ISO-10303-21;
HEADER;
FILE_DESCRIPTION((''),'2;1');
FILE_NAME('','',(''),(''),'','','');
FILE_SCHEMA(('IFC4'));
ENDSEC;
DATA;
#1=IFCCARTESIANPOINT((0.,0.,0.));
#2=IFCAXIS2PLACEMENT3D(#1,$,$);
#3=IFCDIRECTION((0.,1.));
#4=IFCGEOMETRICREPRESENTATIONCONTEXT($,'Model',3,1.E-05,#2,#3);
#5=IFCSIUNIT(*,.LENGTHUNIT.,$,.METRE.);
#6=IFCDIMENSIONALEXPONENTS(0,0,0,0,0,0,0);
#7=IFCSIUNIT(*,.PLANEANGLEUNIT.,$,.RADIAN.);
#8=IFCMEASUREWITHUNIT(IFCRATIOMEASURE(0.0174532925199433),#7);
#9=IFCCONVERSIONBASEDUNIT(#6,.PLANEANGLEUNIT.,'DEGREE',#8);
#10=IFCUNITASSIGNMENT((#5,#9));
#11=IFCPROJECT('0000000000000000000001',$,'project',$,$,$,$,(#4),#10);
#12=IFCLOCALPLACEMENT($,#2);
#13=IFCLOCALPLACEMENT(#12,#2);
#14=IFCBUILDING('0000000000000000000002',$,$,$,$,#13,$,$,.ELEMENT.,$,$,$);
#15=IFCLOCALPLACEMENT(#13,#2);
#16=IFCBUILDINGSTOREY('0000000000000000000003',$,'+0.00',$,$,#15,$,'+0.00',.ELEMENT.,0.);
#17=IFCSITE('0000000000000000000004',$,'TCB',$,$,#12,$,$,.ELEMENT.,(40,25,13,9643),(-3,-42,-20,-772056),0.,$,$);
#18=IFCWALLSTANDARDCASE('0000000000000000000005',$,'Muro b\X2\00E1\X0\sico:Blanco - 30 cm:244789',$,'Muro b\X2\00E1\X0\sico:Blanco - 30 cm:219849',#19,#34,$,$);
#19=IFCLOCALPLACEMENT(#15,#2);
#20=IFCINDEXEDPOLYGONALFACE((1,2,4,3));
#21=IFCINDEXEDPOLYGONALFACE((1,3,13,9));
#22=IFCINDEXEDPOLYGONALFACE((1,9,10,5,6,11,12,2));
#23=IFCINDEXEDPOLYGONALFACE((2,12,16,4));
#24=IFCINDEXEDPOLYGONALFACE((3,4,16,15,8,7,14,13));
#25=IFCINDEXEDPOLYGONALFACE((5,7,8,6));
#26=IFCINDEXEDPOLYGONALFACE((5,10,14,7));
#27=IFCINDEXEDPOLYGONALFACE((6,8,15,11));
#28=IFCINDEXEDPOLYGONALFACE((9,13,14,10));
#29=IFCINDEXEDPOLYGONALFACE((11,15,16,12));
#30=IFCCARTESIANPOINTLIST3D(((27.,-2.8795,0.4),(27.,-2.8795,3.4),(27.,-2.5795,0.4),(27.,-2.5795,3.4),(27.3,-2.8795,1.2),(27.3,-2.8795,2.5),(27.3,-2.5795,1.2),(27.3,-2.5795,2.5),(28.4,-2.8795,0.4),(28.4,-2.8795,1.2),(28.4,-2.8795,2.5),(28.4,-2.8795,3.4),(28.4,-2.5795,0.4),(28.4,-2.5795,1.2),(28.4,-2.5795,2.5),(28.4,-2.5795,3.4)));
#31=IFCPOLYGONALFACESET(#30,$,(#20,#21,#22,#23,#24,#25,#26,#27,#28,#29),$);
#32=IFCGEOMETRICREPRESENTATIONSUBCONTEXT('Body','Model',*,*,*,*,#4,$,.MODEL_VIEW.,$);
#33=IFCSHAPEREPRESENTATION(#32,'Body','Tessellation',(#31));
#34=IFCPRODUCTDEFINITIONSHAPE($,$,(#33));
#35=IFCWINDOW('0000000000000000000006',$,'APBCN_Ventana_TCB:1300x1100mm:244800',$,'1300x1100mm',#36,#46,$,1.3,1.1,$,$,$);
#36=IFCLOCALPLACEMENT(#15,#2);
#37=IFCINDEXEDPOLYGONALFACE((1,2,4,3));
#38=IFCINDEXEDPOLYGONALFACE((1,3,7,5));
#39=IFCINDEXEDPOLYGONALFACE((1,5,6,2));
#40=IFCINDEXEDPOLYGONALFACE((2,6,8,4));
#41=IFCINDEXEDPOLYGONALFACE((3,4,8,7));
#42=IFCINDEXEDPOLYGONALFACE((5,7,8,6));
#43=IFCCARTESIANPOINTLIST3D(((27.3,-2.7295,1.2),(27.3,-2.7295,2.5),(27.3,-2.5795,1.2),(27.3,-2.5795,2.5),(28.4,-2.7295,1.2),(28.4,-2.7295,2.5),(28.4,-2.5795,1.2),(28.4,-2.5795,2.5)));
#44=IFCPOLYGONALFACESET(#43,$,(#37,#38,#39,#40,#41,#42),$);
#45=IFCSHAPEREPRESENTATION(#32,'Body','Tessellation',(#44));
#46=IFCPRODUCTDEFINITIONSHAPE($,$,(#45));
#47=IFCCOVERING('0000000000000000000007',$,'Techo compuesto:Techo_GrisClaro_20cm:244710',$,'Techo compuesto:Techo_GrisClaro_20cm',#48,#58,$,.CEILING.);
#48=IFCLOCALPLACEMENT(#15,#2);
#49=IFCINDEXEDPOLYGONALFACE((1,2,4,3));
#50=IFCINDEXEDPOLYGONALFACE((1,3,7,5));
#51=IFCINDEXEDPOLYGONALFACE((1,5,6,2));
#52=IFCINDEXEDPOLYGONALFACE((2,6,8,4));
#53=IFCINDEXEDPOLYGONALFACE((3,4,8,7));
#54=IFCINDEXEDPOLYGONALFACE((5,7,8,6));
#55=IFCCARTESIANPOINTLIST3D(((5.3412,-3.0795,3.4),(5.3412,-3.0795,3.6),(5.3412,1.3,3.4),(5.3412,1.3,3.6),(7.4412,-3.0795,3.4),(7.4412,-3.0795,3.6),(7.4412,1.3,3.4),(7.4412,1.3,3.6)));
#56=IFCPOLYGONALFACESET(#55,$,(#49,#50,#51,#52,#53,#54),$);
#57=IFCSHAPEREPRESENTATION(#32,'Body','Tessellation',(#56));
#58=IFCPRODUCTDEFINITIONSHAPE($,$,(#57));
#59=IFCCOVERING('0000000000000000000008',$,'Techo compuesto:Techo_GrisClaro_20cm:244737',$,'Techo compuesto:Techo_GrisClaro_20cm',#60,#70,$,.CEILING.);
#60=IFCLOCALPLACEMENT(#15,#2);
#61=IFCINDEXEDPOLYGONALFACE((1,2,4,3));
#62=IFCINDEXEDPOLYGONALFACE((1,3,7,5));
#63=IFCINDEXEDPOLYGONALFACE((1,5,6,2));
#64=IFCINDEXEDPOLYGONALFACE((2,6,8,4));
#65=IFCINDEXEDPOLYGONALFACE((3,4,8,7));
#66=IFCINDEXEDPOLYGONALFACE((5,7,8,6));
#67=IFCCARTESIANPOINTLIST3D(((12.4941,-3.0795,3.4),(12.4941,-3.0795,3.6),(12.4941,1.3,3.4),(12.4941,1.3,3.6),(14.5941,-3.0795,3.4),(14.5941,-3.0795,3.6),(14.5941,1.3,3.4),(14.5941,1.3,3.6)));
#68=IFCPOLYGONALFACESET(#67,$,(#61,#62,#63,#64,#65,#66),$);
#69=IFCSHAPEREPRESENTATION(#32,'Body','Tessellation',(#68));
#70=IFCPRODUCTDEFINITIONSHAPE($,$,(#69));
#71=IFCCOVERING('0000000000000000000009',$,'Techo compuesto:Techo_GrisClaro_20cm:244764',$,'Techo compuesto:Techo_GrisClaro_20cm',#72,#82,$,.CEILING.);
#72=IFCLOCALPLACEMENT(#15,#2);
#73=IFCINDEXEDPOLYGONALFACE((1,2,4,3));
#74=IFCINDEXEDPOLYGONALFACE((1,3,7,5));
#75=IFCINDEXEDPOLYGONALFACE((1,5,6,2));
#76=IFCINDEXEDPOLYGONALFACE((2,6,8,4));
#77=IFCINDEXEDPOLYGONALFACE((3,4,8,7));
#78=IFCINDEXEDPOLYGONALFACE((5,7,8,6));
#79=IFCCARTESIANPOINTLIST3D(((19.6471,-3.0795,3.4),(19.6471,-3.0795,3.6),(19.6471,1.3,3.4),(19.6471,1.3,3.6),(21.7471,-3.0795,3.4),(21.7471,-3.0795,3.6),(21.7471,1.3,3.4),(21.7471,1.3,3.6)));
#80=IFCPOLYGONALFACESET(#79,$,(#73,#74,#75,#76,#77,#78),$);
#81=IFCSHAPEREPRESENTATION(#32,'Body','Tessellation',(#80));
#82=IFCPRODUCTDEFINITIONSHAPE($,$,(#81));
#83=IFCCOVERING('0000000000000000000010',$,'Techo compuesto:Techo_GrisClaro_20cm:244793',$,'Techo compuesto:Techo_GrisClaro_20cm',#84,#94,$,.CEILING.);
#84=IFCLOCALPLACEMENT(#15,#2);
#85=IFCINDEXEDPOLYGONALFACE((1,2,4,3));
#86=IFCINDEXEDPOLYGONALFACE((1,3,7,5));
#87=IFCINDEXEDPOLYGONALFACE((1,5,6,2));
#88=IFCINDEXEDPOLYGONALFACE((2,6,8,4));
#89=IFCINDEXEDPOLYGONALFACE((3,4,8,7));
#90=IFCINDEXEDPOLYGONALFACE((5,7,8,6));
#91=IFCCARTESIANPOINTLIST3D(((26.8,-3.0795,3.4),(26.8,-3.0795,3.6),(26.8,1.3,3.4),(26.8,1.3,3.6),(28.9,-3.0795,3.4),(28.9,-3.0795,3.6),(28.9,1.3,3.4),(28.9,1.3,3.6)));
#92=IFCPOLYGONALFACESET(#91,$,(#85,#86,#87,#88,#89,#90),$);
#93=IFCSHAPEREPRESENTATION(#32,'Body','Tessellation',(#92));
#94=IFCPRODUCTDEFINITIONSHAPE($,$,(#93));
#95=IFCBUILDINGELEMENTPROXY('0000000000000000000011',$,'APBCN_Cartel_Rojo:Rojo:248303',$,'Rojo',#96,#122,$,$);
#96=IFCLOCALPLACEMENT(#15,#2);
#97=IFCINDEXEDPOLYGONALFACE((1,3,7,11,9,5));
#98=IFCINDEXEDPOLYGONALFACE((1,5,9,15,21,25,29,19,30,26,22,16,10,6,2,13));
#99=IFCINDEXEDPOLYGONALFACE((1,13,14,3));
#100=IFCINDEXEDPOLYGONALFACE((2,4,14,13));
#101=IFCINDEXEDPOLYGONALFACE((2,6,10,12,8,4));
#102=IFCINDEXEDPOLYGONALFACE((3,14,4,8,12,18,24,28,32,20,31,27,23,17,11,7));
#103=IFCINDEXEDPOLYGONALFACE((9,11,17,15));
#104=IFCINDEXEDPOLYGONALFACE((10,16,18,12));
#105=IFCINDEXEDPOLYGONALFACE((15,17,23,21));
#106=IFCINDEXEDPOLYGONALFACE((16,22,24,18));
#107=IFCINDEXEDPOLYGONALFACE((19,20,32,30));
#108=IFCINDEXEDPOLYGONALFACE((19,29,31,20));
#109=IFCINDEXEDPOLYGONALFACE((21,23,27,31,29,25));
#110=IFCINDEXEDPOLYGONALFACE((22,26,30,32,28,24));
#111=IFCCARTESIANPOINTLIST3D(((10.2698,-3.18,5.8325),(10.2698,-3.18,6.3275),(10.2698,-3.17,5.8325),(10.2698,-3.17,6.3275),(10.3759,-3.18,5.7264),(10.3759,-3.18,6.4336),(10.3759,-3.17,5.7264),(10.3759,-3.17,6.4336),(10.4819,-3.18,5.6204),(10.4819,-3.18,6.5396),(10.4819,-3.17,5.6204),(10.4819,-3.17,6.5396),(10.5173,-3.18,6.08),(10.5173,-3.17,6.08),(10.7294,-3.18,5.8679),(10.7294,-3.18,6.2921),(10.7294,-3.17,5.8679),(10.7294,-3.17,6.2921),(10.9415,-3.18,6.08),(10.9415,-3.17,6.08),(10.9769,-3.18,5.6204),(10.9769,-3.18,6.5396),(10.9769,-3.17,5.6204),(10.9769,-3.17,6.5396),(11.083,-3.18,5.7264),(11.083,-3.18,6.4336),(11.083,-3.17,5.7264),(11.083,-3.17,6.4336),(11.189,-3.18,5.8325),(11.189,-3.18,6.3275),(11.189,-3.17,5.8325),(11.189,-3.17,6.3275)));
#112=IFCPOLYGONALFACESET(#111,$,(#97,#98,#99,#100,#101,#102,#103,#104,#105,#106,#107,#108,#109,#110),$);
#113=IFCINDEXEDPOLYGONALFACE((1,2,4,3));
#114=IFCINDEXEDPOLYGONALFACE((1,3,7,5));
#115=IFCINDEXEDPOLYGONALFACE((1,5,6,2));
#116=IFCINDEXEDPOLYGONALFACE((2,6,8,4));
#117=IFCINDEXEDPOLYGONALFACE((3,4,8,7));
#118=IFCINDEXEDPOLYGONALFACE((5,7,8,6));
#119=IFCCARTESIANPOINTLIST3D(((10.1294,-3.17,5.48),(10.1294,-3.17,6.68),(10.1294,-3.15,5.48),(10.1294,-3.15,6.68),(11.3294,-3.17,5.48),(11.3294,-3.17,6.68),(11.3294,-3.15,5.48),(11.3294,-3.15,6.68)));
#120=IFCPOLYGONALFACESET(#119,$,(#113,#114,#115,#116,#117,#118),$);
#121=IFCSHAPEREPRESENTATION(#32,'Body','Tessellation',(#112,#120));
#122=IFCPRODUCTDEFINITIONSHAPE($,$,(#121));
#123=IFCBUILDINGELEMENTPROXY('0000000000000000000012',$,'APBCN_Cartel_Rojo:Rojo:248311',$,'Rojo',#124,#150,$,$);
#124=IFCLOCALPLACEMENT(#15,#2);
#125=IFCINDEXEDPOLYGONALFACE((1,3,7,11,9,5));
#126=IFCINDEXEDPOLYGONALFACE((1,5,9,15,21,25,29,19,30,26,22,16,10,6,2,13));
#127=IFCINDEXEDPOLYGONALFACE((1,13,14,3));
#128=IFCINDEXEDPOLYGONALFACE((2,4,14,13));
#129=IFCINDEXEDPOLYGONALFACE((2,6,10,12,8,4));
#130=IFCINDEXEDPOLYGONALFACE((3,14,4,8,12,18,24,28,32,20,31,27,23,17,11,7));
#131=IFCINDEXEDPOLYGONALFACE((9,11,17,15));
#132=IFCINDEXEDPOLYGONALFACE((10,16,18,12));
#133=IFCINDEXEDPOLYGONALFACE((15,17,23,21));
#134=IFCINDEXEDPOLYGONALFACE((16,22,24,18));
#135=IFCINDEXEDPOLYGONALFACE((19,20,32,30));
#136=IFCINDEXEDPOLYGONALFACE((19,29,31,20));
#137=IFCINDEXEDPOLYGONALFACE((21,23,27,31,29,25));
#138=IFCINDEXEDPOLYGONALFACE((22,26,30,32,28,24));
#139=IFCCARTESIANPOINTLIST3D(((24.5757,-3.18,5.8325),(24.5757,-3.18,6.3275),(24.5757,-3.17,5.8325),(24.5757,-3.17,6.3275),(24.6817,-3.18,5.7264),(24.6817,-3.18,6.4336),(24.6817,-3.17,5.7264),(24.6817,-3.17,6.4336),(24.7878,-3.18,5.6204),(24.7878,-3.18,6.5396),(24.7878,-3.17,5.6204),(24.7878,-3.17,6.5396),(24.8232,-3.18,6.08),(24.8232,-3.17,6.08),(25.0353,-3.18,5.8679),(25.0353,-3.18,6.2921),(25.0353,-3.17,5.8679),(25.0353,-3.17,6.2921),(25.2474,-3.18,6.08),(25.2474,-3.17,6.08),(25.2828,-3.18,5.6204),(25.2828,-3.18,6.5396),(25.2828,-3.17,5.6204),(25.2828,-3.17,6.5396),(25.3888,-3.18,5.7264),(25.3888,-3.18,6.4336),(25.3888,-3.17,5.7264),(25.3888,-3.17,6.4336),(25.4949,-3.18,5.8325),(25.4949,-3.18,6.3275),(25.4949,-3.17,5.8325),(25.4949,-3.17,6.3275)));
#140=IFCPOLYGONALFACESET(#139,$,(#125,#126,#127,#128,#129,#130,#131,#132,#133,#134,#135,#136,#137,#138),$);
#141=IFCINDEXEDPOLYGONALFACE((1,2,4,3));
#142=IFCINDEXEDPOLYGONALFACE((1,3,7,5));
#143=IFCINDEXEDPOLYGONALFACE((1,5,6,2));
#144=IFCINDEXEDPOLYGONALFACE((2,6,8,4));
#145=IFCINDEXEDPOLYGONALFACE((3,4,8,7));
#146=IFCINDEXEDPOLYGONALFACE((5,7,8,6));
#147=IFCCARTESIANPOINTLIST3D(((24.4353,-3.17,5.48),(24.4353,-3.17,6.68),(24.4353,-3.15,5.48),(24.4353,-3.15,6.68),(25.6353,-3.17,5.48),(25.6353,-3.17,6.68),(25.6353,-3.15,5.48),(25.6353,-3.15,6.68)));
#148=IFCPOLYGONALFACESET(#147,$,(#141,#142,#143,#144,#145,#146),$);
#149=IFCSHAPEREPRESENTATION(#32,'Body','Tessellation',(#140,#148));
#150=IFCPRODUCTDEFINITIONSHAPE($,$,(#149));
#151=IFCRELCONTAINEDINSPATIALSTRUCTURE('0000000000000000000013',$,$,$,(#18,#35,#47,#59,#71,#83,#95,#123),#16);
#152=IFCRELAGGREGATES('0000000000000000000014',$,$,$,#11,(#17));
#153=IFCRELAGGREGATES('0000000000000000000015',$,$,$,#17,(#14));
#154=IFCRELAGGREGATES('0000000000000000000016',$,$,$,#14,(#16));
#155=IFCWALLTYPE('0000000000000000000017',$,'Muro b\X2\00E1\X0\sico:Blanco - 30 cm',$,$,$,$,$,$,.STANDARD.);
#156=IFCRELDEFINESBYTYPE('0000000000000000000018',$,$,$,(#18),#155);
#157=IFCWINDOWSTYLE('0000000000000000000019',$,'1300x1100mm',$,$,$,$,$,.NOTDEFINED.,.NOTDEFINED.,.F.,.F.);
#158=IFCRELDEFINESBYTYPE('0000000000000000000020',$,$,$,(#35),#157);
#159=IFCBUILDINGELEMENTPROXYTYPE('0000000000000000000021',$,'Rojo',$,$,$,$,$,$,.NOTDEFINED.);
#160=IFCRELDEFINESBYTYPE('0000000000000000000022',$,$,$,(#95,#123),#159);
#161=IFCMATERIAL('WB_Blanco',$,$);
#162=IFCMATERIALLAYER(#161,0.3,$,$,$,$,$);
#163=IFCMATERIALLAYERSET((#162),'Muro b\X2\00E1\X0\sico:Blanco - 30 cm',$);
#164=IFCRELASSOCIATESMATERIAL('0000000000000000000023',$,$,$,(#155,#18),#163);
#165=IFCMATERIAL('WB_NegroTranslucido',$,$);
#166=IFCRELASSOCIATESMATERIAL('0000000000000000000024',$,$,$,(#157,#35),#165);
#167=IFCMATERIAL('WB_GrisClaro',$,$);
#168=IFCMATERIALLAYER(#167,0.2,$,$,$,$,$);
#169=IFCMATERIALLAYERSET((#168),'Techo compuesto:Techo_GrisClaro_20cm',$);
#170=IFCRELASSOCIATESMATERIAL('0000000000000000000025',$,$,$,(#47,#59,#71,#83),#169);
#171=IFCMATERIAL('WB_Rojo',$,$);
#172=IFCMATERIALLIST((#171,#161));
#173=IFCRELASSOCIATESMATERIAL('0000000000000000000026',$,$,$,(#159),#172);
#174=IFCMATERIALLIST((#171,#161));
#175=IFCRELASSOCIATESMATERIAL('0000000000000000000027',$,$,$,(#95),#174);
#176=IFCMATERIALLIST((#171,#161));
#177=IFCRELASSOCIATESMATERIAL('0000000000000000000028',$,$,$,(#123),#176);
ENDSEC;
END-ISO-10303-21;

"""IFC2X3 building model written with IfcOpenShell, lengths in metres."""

from ifc_helpers import new_model, entity, si_unit, converted_unit, direction, frame, frame_2d, origin, origin_2d_with_axis, place, context, subcontext, project, spatial, polyline, rectangle, outline, extrude, source, transform, mapped, material, material_list, layer, layer_set, layer_usage, type_object, type_shapes, element, fill, save


model = new_model("IFC2X3")

# Units and contexts
model_context = context("Model", 3, precision=1e-05, world=origin(), true_north=direction((0.0, 1.0)))
body_context = subcontext(model_context, "Body", "Model", "MODEL_VIEW")
ifc_project = project(units=[si_unit("LENGTHUNIT", "METRE"), converted_unit("PLANEANGLEUNIT", "DEGREE", entity("IfcRatioMeasure", 0.0174532925199433), si_unit("PLANEANGLEUNIT", "RADIAN"), dimensions=[0, 0, 0, 0, 0, 0, 0])], contexts=[model_context])

# Site, building, storey
site_placement = place(None, origin())
site = spatial("IfcSite", under=ifc_project, at=site_placement, Name="TCB", CompositionType="ELEMENT", RefLatitude=(40, 25, 13, 9643), RefLongitude=(-3, -42, -20, -772056), RefElevation=0.0)
building_placement = place(site_placement, origin())
building = spatial("IfcBuilding", under=site, at=building_placement, CompositionType="ELEMENT")
storey_placement = place(building_placement, origin())
storey = spatial("IfcBuildingStorey", under=building, at=storey_placement, Name="+0.00", LongName="+0.00", CompositionType="ELEMENT", Elevation=0.0)

# Wall, opening, window
ifc_material_1 = material(Name="WB_Blanco")
ifc_layer_1 = layer(ifc_material_1, 0.3)
ifc_layer_set_1 = layer_set([ifc_layer_1], Name="Muro básico:Blanco - 30 cm")
wall_type = type_object("IfcWallType", Name="Muro básico:Blanco - 30 cm", PredefinedType="STANDARD", material=ifc_layer_set_1)
ifc_material_2 = material(Name="WB_NegroTranslucido")
window_style = type_object("IfcWindowStyle", Name="1300x1100mm", ConstructionType="NOTDEFINED", OperationType="NOTDEFINED", ParameterTakesPrecedence=False, Sizeable=False, material=ifc_material_2)
shared_shape_1 = source(origin(), body_context, "Body", "SweptSolid", [
    extrude(rectangle(XDim=1.1, YDim=0.15, at=origin_2d_with_axis()), frame((0.55, 0.075, 0.0)), (0.0, 0.0, 1.0), 1.3),
])
type_shapes(window_style, [shared_shape_1])
ifc_layer_usage_1 = layer_usage(ifc_layer_set_1, "AXIS2", "NEGATIVE", 0.15)
wall_1_placement = place(storey_placement, frame((28.4, -2.7295, 0.4), z_axis=(0.0, 0.0, 1.0), x_axis=(-1.0, 0.0, 0.0)))
wall_1 = element("IfcWallStandardCase", 1, at=wall_1_placement, inside=storey, type_object=wall_type, material=ifc_layer_usage_1, Name="Muro básico:Blanco - 30 cm:244789", ObjectType="Muro básico:Blanco - 30 cm:219849", context=body_context, shape_type="SweptSolid", body=[
    extrude(rectangle(XDim=1.4, YDim=0.3, at=frame_2d((0.7, 0.0), x_axis=(-1.0, 0.0))), origin(), (0.0, 0.0, 1.0), 3.0),
])
opening_1_placement = place(wall_1_placement, frame((0.0, -0.15, 0.8)))
opening_1 = element("IfcOpeningElement", 2, at=opening_1_placement, cuts=wall_1, ObjectType="Opening", context=body_context, shape_type="SweptSolid", body=[
    extrude(rectangle(XDim=1.3, YDim=1.1, at=frame_2d((0.65, 0.55), x_axis=(1.0, 0.0))), frame((0.0, 0.0, 0.0), z_axis=(0.0, 1.0, 0.0), x_axis=(0.0, 0.0, 1.0)), (0.0, 0.0, 1.0), 0.3),
])
window_1_placement = place(opening_1_placement, origin())
window_1 = element("IfcWindow", 3, at=window_1_placement, inside=storey, type_object=window_style, material=ifc_material_2, Name="APBCN_Ventana_TCB:1300x1100mm:244800", ObjectType="1300x1100mm", OverallHeight=1.3, OverallWidth=1.1, context=body_context, shape_type="MappedRepresentation", body=[
    mapped(shared_shape_1, transform((0.0, 0.0, 0.0), scale=1.0)),
])
fill(opening_1, window_1)

# Coverings
ifc_material_3 = material(Name="WB_GrisClaro")
ifc_layer_2 = layer(ifc_material_3, 0.2)
ifc_layer_set_2 = layer_set([ifc_layer_2], Name="Techo compuesto:Techo_GrisClaro_20cm")
ifc_layer_usage_2 = layer_usage(ifc_layer_set_2, "AXIS3", "POSITIVE", 0.0)
covering_1_placement = place(storey_placement, frame((5.3412, -3.0795, 3.4)))
element("IfcCovering", 4, at=covering_1_placement, inside=storey, material=ifc_layer_usage_2, Name="Techo compuesto:Techo_GrisClaro_20cm:244710", ObjectType="Techo compuesto:Techo_GrisClaro_20cm", PredefinedType="CEILING", context=body_context, shape_type="SweptSolid", body=[
    extrude(rectangle(XDim=2.1, YDim=4.3795, at=origin_2d_with_axis()), frame((1.05, 2.1897, 0.0), z_axis=(0.0, 0.0, 1.0), x_axis=(-1.0, 0.0, 0.0)), (0.0, 0.0, 1.0), 0.2),
])
ifc_layer_usage_3 = layer_usage(ifc_layer_set_2, "AXIS3", "POSITIVE", 0.0)
covering_2_placement = place(storey_placement, frame((12.4941, -3.0795, 3.4)))
element("IfcCovering", 5, at=covering_2_placement, inside=storey, material=ifc_layer_usage_3, Name="Techo compuesto:Techo_GrisClaro_20cm:244737", ObjectType="Techo compuesto:Techo_GrisClaro_20cm", PredefinedType="CEILING", context=body_context, shape_type="SweptSolid", body=[
    extrude(rectangle(XDim=2.1, YDim=4.3795, at=frame_2d((0.0, 0.0), x_axis=(1.0, 0.0))), frame((1.05, 2.1897, 0.0), z_axis=(0.0, 0.0, 1.0), x_axis=(-1.0, 0.0, 0.0)), (0.0, 0.0, 1.0), 0.2),
])
ifc_layer_usage_4 = layer_usage(ifc_layer_set_2, "AXIS3", "POSITIVE", 0.0)
covering_3_placement = place(storey_placement, frame((19.6471, -3.0795, 3.4)))
element("IfcCovering", 6, at=covering_3_placement, inside=storey, material=ifc_layer_usage_4, Name="Techo compuesto:Techo_GrisClaro_20cm:244764", ObjectType="Techo compuesto:Techo_GrisClaro_20cm", PredefinedType="CEILING", context=body_context, shape_type="SweptSolid", body=[
    extrude(rectangle(XDim=2.1, YDim=4.3795, at=frame_2d((0.0, 0.0), x_axis=(1.0, 0.0))), frame((1.05, 2.1897, 0.0), z_axis=(0.0, 0.0, 1.0), x_axis=(-1.0, 0.0, 0.0)), (0.0, 0.0, 1.0), 0.2),
])
ifc_layer_usage_5 = layer_usage(ifc_layer_set_2, "AXIS3", "POSITIVE", 0.0)
covering_4_placement = place(storey_placement, frame((26.8, -3.0795, 3.4)))
element("IfcCovering", 7, at=covering_4_placement, inside=storey, material=ifc_layer_usage_5, Name="Techo compuesto:Techo_GrisClaro_20cm:244793", ObjectType="Techo compuesto:Techo_GrisClaro_20cm", PredefinedType="CEILING", context=body_context, shape_type="SweptSolid", body=[
    extrude(rectangle(XDim=2.1, YDim=4.3795, at=frame_2d((0.0, 0.0), x_axis=(1.0, 0.0))), frame((1.05, 2.1897, 0.0), z_axis=(0.0, 0.0, 1.0), x_axis=(-1.0, 0.0, 0.0)), (0.0, 0.0, 1.0), 0.2),
])

# Building element proxies
ifc_material_4 = material(Name="WB_Rojo")
ifc_material_list_1 = material_list([ifc_material_4, ifc_material_1])
ifc_material_list_2 = material_list([ifc_material_4, ifc_material_1])
building_element_proxy_type_1 = type_object("IfcBuildingElementProxyType", Name="Rojo", PredefinedType="NOTDEFINED", material=ifc_material_list_2)
shared_shape_2 = source(origin(), body_context, "Body", "SweptSolid", [
    extrude(outline(polyline([(-0.15, -0.5), (0.0, -0.5), (0.15, -0.5), (0.15, -0.15), (0.5, -0.15), (0.5, 0.0), (0.5, 0.15), (0.15, 0.15), (0.15, 0.5), (0.0, 0.5), (-0.15, 0.5), (-0.15, 0.15), (-0.5, 0.15), (-0.5, 0.0), (-0.5, -0.15), (-0.15, -0.15), (-0.15, -0.5)])), frame((0.0, 0.0, 0.02), z_axis=(0.0, 0.0, 1.0), x_axis=(-0.707107, 0.707107, 0.0)), (0.0, 0.0, 1.0), 0.01),
    extrude(rectangle(XDim=1.2, YDim=1.2, at=origin_2d_with_axis()), origin(), (0.0, 0.0, 1.0), 0.02),
])
type_shapes(building_element_proxy_type_1, [shared_shape_2])
proxy_1_placement = place(storey_placement, frame((10.7294, -3.15, 6.08), z_axis=(0.0, -1.0, 0.0), x_axis=(1.0, 0.0, 0.0)))
element("IfcBuildingElementProxy", 8, at=proxy_1_placement, inside=storey, type_object=building_element_proxy_type_1, material=ifc_material_list_1, Name="APBCN_Cartel_Rojo:Rojo:248303", ObjectType="Rojo", context=body_context, shape_type="MappedRepresentation", body=[
    mapped(shared_shape_2, transform((0.0, 0.0, 0.0), scale=1.0)),
])
ifc_material_list_3 = material_list([ifc_material_4, ifc_material_1])
proxy_2_placement = place(storey_placement, frame((25.0353, -3.15, 6.08), z_axis=(0.0, -1.0, 0.0), x_axis=(1.0, 0.0, 0.0)))
element("IfcBuildingElementProxy", 9, at=proxy_2_placement, inside=storey, type_object=building_element_proxy_type_1, material=ifc_material_list_3, Name="APBCN_Cartel_Rojo:Rojo:248311", ObjectType="Rojo", context=body_context, shape_type="MappedRepresentation", body=[
    mapped(shared_shape_2, transform((0.0, 0.0, 0.0), scale=1.0)),
])

save(model, "model.ifc")
